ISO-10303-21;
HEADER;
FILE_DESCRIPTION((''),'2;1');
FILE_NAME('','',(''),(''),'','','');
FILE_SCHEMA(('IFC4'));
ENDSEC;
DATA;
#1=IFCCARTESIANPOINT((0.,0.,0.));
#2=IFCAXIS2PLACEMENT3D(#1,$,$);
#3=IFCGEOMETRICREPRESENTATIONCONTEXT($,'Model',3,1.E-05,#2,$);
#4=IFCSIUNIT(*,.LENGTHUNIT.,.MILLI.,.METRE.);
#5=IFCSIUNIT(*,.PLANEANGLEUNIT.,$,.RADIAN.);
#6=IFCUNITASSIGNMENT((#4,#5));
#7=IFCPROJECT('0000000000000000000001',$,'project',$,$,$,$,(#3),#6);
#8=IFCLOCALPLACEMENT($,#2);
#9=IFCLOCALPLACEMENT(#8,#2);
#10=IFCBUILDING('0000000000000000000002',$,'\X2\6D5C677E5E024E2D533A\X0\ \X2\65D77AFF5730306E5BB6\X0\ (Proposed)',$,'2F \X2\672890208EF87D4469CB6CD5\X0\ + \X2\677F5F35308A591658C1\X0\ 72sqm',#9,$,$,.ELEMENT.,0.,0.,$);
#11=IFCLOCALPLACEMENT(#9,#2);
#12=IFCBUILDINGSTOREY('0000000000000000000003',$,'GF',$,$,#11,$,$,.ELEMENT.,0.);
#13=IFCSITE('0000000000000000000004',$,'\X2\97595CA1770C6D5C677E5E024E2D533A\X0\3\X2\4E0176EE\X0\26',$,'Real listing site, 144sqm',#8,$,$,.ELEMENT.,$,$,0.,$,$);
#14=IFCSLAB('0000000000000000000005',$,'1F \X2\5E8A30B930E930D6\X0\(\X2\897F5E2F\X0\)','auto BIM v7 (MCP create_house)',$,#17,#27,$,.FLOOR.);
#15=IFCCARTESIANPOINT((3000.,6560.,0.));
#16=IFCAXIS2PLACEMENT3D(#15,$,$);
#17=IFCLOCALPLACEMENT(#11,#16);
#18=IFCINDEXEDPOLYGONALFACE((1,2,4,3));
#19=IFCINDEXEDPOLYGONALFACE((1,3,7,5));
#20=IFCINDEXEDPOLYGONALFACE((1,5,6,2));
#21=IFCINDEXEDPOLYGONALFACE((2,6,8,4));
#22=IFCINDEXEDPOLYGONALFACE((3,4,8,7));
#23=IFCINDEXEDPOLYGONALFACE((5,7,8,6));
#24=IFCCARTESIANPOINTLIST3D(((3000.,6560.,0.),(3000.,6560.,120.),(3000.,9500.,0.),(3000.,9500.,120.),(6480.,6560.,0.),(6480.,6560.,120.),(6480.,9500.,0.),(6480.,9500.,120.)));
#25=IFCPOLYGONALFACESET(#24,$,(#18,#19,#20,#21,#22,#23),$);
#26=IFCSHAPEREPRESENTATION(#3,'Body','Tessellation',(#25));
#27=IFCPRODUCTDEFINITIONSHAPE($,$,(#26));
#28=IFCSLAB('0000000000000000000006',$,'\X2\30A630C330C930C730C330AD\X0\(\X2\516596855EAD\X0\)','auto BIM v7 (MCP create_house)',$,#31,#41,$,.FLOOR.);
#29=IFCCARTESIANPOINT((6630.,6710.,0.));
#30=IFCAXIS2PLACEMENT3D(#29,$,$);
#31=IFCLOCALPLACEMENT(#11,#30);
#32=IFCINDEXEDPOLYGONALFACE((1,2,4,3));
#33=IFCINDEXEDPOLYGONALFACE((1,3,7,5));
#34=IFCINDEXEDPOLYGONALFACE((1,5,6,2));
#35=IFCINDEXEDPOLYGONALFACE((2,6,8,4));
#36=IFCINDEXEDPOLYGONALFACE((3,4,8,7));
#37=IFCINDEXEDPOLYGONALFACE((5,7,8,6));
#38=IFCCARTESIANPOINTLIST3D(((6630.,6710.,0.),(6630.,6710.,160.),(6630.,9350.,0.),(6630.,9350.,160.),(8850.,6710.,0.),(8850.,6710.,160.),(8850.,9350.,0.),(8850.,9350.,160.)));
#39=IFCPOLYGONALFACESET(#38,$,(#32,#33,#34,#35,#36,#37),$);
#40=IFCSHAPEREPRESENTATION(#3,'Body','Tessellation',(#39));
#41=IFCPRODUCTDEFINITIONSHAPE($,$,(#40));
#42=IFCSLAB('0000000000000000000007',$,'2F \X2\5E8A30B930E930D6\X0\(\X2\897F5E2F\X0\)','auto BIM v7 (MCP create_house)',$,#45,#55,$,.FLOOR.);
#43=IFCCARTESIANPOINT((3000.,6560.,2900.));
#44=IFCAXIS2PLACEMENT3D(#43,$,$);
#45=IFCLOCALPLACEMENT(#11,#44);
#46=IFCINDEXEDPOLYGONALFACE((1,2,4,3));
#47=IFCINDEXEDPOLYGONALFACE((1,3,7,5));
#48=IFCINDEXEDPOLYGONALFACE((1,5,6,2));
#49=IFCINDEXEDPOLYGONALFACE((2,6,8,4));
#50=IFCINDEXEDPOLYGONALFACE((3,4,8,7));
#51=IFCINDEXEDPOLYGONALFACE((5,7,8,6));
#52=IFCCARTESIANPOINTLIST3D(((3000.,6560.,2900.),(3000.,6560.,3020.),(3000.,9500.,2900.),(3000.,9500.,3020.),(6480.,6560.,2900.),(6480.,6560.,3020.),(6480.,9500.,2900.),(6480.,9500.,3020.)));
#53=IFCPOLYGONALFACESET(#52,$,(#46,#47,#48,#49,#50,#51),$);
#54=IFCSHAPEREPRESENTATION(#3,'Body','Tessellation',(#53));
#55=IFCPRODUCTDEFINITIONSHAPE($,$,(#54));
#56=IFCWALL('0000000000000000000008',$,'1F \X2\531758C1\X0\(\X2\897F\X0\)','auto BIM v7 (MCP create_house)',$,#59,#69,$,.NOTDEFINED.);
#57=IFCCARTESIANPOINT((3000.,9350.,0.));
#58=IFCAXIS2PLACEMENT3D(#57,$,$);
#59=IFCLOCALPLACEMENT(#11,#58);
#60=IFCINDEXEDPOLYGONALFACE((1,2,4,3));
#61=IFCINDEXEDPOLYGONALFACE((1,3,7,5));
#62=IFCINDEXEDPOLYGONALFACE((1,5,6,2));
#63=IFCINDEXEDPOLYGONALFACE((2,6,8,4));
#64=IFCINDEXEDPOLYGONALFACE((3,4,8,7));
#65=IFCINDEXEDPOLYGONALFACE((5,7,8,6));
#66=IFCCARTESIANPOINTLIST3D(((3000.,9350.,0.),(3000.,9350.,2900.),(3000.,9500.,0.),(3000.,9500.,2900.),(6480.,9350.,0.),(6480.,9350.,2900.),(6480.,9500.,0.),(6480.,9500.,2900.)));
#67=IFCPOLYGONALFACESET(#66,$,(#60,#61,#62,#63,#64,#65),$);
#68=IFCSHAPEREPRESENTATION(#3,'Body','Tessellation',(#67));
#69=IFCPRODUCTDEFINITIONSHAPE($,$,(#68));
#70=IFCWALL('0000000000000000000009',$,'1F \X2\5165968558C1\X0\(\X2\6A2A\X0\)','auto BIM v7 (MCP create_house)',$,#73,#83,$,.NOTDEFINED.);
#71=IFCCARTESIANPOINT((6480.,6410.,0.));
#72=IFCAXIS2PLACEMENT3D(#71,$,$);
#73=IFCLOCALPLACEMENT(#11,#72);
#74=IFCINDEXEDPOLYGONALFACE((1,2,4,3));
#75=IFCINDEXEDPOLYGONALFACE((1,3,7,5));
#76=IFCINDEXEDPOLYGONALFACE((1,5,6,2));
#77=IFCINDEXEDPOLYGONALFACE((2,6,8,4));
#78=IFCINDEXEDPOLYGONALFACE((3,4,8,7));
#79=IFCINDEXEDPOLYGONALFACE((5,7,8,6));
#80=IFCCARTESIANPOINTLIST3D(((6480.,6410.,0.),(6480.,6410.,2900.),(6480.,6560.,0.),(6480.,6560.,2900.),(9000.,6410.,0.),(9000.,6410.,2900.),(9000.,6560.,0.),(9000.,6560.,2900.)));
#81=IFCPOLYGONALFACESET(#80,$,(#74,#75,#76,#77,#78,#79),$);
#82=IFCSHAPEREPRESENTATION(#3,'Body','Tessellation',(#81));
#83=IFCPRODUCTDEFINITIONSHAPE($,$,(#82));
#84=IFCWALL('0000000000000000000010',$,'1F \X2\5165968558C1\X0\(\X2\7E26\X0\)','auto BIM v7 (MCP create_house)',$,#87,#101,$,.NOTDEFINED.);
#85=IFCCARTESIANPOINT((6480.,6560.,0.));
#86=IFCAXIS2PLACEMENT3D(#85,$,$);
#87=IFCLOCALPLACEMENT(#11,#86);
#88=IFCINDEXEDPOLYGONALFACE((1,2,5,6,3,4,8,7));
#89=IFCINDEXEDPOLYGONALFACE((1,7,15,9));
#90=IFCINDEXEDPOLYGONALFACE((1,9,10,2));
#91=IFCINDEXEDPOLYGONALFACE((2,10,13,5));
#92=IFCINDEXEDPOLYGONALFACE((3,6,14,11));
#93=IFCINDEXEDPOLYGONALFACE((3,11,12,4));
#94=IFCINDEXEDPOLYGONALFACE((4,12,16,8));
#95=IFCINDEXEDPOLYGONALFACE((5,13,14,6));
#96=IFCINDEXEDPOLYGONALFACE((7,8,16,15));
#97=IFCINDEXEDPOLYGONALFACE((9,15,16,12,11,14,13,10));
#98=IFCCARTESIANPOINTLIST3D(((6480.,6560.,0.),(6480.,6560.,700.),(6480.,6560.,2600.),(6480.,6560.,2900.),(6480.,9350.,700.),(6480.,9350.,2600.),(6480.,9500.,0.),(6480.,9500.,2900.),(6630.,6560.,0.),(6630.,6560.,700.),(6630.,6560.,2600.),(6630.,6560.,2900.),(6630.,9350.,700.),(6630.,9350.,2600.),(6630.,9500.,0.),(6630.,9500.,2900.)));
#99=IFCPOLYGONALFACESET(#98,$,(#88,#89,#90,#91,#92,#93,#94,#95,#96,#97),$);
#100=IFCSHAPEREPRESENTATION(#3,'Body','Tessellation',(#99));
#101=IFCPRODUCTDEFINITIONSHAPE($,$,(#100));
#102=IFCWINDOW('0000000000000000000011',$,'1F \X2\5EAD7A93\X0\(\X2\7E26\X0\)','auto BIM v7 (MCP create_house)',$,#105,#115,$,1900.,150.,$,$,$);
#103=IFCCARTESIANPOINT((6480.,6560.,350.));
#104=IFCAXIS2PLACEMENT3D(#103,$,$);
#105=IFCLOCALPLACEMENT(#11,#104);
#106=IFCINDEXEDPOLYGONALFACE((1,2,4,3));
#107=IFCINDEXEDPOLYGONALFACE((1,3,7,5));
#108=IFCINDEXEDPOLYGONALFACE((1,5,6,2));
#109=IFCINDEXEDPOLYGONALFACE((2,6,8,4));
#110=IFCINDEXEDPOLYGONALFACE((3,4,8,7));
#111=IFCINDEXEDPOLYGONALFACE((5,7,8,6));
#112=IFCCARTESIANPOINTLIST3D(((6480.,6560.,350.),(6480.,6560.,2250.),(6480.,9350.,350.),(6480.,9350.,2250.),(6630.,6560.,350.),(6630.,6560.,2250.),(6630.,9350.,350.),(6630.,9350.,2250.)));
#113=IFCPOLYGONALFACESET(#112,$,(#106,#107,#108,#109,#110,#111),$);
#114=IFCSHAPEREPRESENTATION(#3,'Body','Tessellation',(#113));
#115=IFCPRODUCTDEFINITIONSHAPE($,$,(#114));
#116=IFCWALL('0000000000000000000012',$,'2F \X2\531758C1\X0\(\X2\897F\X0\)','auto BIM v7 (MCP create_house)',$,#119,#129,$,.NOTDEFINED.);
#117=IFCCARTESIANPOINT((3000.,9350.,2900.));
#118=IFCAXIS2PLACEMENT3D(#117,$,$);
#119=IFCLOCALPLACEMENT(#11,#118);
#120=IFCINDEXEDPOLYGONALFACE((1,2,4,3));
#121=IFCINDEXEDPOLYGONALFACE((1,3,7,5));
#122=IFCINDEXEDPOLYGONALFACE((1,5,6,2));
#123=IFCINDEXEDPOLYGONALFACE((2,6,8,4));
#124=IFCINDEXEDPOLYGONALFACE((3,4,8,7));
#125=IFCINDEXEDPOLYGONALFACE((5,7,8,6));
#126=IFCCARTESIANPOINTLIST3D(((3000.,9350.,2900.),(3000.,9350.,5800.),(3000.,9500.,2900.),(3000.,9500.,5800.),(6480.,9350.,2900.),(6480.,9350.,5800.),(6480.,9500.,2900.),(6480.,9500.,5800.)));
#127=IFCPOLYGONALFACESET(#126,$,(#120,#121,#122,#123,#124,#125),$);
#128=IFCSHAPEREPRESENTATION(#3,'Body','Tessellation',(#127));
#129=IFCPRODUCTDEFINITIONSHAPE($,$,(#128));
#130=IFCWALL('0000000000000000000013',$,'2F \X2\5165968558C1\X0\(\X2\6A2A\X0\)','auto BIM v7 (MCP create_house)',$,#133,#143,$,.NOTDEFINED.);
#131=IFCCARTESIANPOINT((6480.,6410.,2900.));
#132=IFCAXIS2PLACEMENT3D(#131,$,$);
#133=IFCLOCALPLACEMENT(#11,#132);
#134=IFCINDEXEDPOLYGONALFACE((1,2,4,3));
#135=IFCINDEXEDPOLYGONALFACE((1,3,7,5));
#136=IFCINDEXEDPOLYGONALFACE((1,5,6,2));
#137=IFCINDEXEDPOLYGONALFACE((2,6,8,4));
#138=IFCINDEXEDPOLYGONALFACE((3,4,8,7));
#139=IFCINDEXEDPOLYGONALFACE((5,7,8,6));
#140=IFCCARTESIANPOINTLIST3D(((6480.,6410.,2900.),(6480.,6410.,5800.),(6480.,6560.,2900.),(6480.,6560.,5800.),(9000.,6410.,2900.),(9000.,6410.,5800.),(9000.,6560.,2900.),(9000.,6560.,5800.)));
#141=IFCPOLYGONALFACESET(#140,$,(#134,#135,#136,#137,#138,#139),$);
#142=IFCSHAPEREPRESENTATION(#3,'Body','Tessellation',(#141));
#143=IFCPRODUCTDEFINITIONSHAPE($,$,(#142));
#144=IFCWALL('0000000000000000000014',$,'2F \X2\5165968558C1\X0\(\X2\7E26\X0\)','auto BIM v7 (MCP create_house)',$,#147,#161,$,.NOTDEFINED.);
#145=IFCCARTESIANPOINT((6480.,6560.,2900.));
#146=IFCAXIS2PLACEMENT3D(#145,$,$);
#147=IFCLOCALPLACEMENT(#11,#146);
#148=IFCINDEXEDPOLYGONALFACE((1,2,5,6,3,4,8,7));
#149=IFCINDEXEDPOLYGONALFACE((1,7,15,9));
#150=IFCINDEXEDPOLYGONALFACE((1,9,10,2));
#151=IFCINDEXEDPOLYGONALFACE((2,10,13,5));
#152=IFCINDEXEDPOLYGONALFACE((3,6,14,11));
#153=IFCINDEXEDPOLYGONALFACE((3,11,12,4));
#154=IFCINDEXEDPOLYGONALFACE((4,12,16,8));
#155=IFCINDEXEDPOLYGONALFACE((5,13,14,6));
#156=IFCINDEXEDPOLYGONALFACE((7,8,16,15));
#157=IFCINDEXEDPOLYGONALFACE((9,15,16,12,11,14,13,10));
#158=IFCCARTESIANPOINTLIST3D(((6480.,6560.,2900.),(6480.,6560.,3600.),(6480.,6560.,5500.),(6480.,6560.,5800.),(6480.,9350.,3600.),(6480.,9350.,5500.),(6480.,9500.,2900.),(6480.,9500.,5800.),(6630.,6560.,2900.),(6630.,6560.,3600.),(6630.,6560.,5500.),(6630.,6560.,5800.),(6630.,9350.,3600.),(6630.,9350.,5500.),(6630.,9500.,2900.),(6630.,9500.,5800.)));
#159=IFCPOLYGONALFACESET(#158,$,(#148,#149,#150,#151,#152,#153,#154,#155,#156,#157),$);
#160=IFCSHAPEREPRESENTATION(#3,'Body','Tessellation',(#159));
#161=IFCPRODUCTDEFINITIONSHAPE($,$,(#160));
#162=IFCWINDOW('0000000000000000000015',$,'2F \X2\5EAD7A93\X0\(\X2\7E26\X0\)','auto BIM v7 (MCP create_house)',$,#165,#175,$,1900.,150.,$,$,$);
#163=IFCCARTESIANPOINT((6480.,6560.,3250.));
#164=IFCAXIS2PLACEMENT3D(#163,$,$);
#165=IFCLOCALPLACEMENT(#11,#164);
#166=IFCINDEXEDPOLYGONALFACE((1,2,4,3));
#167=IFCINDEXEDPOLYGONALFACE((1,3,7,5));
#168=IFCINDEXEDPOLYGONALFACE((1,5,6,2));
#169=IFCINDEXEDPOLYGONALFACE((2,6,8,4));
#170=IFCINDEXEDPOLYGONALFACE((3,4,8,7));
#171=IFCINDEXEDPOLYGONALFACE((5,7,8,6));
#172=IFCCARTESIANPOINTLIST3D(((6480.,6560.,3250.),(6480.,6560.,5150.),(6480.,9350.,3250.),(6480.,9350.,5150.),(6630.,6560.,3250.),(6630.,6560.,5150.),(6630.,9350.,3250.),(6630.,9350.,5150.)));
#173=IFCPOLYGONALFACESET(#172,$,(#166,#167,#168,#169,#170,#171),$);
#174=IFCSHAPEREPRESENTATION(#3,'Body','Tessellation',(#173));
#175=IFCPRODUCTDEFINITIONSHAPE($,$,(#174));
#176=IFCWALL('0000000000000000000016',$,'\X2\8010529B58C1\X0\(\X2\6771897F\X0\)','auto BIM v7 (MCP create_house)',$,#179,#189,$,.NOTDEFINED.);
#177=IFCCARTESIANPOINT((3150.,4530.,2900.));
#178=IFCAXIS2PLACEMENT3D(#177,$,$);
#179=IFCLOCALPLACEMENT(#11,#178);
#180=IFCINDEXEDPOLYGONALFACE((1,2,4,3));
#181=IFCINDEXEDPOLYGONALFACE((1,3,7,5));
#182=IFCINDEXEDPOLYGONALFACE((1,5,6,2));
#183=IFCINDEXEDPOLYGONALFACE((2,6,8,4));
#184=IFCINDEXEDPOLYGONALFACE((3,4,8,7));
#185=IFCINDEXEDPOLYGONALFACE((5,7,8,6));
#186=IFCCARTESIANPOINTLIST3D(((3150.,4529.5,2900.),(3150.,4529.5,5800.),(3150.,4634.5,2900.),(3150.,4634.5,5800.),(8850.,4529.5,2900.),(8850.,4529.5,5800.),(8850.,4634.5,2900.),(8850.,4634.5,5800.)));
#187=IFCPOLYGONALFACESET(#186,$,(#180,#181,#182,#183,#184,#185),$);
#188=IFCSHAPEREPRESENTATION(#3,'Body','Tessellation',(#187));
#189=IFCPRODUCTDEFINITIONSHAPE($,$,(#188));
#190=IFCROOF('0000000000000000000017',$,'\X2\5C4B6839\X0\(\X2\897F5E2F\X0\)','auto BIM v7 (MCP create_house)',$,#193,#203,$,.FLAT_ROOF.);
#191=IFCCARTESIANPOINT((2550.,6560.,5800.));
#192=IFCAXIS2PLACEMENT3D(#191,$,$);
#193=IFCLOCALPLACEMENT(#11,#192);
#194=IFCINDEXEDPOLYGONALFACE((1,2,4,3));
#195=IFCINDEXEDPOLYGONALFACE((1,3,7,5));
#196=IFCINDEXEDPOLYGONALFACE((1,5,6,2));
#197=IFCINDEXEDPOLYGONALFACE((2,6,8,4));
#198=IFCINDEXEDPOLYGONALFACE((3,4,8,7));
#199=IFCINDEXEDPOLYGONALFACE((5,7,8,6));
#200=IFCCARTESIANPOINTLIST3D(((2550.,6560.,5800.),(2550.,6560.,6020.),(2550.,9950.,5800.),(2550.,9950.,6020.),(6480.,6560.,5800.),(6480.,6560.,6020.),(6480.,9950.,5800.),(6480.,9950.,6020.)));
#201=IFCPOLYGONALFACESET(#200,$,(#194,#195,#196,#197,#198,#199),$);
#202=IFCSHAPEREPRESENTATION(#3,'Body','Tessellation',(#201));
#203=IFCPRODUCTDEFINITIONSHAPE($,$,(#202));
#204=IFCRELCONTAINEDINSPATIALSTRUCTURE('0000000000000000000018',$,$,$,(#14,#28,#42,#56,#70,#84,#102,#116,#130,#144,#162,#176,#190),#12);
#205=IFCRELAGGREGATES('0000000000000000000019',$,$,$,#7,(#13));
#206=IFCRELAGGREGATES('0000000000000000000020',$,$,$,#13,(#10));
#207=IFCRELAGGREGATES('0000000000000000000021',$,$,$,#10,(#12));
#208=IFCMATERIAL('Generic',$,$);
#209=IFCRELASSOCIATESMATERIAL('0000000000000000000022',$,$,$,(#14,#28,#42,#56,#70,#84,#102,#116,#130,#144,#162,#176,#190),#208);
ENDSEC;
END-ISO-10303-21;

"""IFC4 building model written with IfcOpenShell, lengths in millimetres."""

from ifc_helpers import new_model, si_unit, frame, frame_2d, origin, place, context, project, spatial, rectangle, extrude, material, element, fill, save


model = new_model("IFC4")

# Units and contexts
model_context = context("Model", 3, precision=1e-05, world=origin())
ifc_project = project(units=[si_unit("LENGTHUNIT", "METRE", prefix="MILLI"), si_unit("PLANEANGLEUNIT", "RADIAN")], contexts=[model_context])

# Site, building, storey
site_placement = place(None, origin())
site = spatial("IfcSite", under=ifc_project, at=site_placement, Name="静岡県浜松市中区3丁目26", ObjectType="Real listing site, 144sqm", CompositionType="ELEMENT", RefElevation=0.0)
building_placement = place(site_placement, origin())
building = spatial("IfcBuilding", under=site, at=building_placement, Name="浜松市中区 旗竿地の家 (Proposed)", ObjectType="2F 木造軸組構法 + 板張り外壁 72sqm", CompositionType="ELEMENT", ElevationOfRefHeight=0.0, ElevationOfTerrain=0.0)
storey_placement = place(building_placement, origin())
storey = spatial("IfcBuildingStorey", under=building, at=storey_placement, Name="GF", CompositionType="ELEMENT", Elevation=0.0)

# Slabs
ifc_material = material(Name="Generic")
slab_1_placement = place(storey_placement, frame((3000.0, 6560.0, 0.0)))
element("IfcSlab", 1, at=slab_1_placement, inside=storey, material=ifc_material, Name="1F 床スラブ(西帯)", Description="auto BIM v7 (MCP create_house)", PredefinedType="FLOOR", context=model_context, shape_type="SweptSolid", body=[
    extrude(rectangle(XDim=3480.0, YDim=2940.0, at=frame_2d((1740.0, 1470.0))), frame((3000.0, 6560.0, 0.0)), (0.0, 0.0, 1.0), 120.0),
])
slab_2_placement = place(storey_placement, frame((6630.0, 6710.0, 0.0)))
element("IfcSlab", 2, at=slab_2_placement, inside=storey, material=ifc_material, Name="ウッドデッキ(入隅庭)", Description="auto BIM v7 (MCP create_house)", PredefinedType="FLOOR", context=model_context, shape_type="SweptSolid", body=[
    extrude(rectangle(XDim=2220.0, YDim=2640.0, at=frame_2d((1110.0, 1320.0))), frame((6630.0, 6710.0, 0.0)), (0.0, 0.0, 1.0), 160.0),
])
slab_3_placement = place(storey_placement, frame((3000.0, 6560.0, 2900.0)))
element("IfcSlab", 3, at=slab_3_placement, inside=storey, material=ifc_material, Name="2F 床スラブ(西帯)", Description="auto BIM v7 (MCP create_house)", PredefinedType="FLOOR", context=model_context, shape_type="SweptSolid", body=[
    extrude(rectangle(XDim=3480.0, YDim=2940.0, at=frame_2d((1740.0, 1470.0))), frame((3000.0, 6560.0, 2900.0)), (0.0, 0.0, 1.0), 120.0),
])

# Walls
wall_1_placement = place(storey_placement, frame((3000.0, 9350.0, 0.0)))
element("IfcWall", 4, at=wall_1_placement, inside=storey, material=ifc_material, Name="1F 北壁(西)", Description="auto BIM v7 (MCP create_house)", PredefinedType="NOTDEFINED", context=model_context, shape_type="SweptSolid", body=[
    extrude(rectangle(XDim=3480.0, YDim=150.0, at=frame_2d((1740.0, 75.0))), frame((3000.0, 9350.0, 0.0)), (0.0, 0.0, 1.0), 2900.0),
])
wall_2_placement = place(storey_placement, frame((6480.0, 6410.0, 0.0)))
element("IfcWall", 5, at=wall_2_placement, inside=storey, material=ifc_material, Name="1F 入隅壁(横)", Description="auto BIM v7 (MCP create_house)", PredefinedType="NOTDEFINED", context=model_context, shape_type="SweptSolid", body=[
    extrude(rectangle(XDim=2520.0, YDim=150.0, at=frame_2d((1260.0, 75.0))), frame((6480.0, 6410.0, 0.0)), (0.0, 0.0, 1.0), 2900.0),
])

# Wall, opening, window
wall_3_placement = place(storey_placement, frame((6480.0, 6560.0, 0.0)))
wall_3 = element("IfcWall", 6, at=wall_3_placement, inside=storey, material=ifc_material, Name="1F 入隅壁(縦)", Description="auto BIM v7 (MCP create_house)", PredefinedType="NOTDEFINED", context=model_context, shape_type="SweptSolid", body=[
    extrude(rectangle(XDim=150.0, YDim=2940.0, at=frame_2d((75.0, 1470.0))), frame((6480.0, 6560.0, 0.0)), (0.0, 0.0, 1.0), 2900.0),
])
opening_1_placement = place(storey_placement, frame((6480.0, 6560.0, 350.0)))
opening_1 = element("IfcOpeningElement", 7, at=opening_1_placement, cuts=wall_3, PredefinedType="NOTDEFINED", context=model_context, shape_type="SweptSolid", body=[
    extrude(rectangle(XDim=150.0, YDim=2790.0, at=frame_2d((75.0, 1395.0))), frame((6480.0, 6560.0, 350.0)), (0.0, 0.0, 1.0), 1900.0),
])
window_1_placement = place(storey_placement, frame((6480.0, 6560.0, 350.0)))
window_1 = element("IfcWindow", 8, at=window_1_placement, inside=storey, material=ifc_material, Name="1F 庭窓(縦)", Description="auto BIM v7 (MCP create_house)", OverallHeight=1900.0, OverallWidth=150.0, context=model_context, shape_type="SweptSolid", body=[
    extrude(rectangle(XDim=150.0, YDim=2790.0, at=frame_2d((75.0, 1395.0))), frame((6480.0, 6560.0, 350.0)), (0.0, 0.0, 1.0), 1900.0),
])
fill(opening_1, window_1)

# Walls
wall_4_placement = place(storey_placement, frame((3000.0, 9350.0, 2900.0)))
element("IfcWall", 9, at=wall_4_placement, inside=storey, material=ifc_material, Name="2F 北壁(西)", Description="auto BIM v7 (MCP create_house)", PredefinedType="NOTDEFINED", context=model_context, shape_type="SweptSolid", body=[
    extrude(rectangle(XDim=3480.0, YDim=150.0, at=frame_2d((1740.0, 75.0))), frame((3000.0, 9350.0, 2900.0)), (0.0, 0.0, 1.0), 2900.0),
])
wall_5_placement = place(storey_placement, frame((6480.0, 6410.0, 2900.0)))
element("IfcWall", 10, at=wall_5_placement, inside=storey, material=ifc_material, Name="2F 入隅壁(横)", Description="auto BIM v7 (MCP create_house)", PredefinedType="NOTDEFINED", context=model_context, shape_type="SweptSolid", body=[
    extrude(rectangle(XDim=2520.0, YDim=150.0, at=frame_2d((1260.0, 75.0))), frame((6480.0, 6410.0, 2900.0)), (0.0, 0.0, 1.0), 2900.0),
])

# Wall, opening, window
wall_6_placement = place(storey_placement, frame((6480.0, 6560.0, 2900.0)))
wall_6 = element("IfcWall", 11, at=wall_6_placement, inside=storey, material=ifc_material, Name="2F 入隅壁(縦)", Description="auto BIM v7 (MCP create_house)", PredefinedType="NOTDEFINED", context=model_context, shape_type="SweptSolid", body=[
    extrude(rectangle(XDim=150.0, YDim=2940.0, at=frame_2d((75.0, 1470.0))), frame((6480.0, 6560.0, 2900.0)), (0.0, 0.0, 1.0), 2900.0),
])
opening_2_placement = place(storey_placement, frame((6480.0, 6560.0, 3250.0)))
opening_2 = element("IfcOpeningElement", 12, at=opening_2_placement, cuts=wall_6, PredefinedType="NOTDEFINED", context=model_context, shape_type="SweptSolid", body=[
    extrude(rectangle(XDim=150.0, YDim=2790.0, at=frame_2d((75.0, 1395.0))), frame((6480.0, 6560.0, 3250.0)), (0.0, 0.0, 1.0), 1900.0),
])
window_2_placement = place(storey_placement, frame((6480.0, 6560.0, 3250.0)))
window_2 = element("IfcWindow", 13, at=window_2_placement, inside=storey, material=ifc_material, Name="2F 庭窓(縦)", Description="auto BIM v7 (MCP create_house)", OverallHeight=1900.0, OverallWidth=150.0, context=model_context, shape_type="SweptSolid", body=[
    extrude(rectangle(XDim=150.0, YDim=2790.0, at=frame_2d((75.0, 1395.0))), frame((6480.0, 6560.0, 3250.0)), (0.0, 0.0, 1.0), 1900.0),
])
fill(opening_2, window_2)

# Wall
wall_7_placement = place(storey_placement, frame((3150.0, 4530.0, 2900.0)))
element("IfcWall", 14, at=wall_7_placement, inside=storey, material=ifc_material, Name="耐力壁(東西)", Description="auto BIM v7 (MCP create_house)", PredefinedType="NOTDEFINED", context=model_context, shape_type="SweptSolid", body=[
    extrude(rectangle(XDim=5700.0, YDim=105.0, at=frame_2d((2850.0, 52.0))), frame((3150.0, 4530.0, 2900.0)), (0.0, 0.0, 1.0), 2900.0),
])

# Roof
for number, where, name in (
    (15, (2550.0, 6560.0, 5800.0), "屋根(西帯)"),
):
    element("IfcRoof", number, at=place(storey_placement, frame(where)), inside=storey, material=ifc_material, Name=name, Description="auto BIM v7 (MCP create_house)", PredefinedType="FLAT_ROOF", context=model_context, shape_type="SweptSolid", body=[
        extrude(rectangle(XDim=3930.0, YDim=3390.0, at=frame_2d((1965.0, 1695.0))), frame((2550.0, 6560.0, 5800.0)), (0.0, 0.0, 1.0), 220.0),
    ])

save(model, "model.ifc")
